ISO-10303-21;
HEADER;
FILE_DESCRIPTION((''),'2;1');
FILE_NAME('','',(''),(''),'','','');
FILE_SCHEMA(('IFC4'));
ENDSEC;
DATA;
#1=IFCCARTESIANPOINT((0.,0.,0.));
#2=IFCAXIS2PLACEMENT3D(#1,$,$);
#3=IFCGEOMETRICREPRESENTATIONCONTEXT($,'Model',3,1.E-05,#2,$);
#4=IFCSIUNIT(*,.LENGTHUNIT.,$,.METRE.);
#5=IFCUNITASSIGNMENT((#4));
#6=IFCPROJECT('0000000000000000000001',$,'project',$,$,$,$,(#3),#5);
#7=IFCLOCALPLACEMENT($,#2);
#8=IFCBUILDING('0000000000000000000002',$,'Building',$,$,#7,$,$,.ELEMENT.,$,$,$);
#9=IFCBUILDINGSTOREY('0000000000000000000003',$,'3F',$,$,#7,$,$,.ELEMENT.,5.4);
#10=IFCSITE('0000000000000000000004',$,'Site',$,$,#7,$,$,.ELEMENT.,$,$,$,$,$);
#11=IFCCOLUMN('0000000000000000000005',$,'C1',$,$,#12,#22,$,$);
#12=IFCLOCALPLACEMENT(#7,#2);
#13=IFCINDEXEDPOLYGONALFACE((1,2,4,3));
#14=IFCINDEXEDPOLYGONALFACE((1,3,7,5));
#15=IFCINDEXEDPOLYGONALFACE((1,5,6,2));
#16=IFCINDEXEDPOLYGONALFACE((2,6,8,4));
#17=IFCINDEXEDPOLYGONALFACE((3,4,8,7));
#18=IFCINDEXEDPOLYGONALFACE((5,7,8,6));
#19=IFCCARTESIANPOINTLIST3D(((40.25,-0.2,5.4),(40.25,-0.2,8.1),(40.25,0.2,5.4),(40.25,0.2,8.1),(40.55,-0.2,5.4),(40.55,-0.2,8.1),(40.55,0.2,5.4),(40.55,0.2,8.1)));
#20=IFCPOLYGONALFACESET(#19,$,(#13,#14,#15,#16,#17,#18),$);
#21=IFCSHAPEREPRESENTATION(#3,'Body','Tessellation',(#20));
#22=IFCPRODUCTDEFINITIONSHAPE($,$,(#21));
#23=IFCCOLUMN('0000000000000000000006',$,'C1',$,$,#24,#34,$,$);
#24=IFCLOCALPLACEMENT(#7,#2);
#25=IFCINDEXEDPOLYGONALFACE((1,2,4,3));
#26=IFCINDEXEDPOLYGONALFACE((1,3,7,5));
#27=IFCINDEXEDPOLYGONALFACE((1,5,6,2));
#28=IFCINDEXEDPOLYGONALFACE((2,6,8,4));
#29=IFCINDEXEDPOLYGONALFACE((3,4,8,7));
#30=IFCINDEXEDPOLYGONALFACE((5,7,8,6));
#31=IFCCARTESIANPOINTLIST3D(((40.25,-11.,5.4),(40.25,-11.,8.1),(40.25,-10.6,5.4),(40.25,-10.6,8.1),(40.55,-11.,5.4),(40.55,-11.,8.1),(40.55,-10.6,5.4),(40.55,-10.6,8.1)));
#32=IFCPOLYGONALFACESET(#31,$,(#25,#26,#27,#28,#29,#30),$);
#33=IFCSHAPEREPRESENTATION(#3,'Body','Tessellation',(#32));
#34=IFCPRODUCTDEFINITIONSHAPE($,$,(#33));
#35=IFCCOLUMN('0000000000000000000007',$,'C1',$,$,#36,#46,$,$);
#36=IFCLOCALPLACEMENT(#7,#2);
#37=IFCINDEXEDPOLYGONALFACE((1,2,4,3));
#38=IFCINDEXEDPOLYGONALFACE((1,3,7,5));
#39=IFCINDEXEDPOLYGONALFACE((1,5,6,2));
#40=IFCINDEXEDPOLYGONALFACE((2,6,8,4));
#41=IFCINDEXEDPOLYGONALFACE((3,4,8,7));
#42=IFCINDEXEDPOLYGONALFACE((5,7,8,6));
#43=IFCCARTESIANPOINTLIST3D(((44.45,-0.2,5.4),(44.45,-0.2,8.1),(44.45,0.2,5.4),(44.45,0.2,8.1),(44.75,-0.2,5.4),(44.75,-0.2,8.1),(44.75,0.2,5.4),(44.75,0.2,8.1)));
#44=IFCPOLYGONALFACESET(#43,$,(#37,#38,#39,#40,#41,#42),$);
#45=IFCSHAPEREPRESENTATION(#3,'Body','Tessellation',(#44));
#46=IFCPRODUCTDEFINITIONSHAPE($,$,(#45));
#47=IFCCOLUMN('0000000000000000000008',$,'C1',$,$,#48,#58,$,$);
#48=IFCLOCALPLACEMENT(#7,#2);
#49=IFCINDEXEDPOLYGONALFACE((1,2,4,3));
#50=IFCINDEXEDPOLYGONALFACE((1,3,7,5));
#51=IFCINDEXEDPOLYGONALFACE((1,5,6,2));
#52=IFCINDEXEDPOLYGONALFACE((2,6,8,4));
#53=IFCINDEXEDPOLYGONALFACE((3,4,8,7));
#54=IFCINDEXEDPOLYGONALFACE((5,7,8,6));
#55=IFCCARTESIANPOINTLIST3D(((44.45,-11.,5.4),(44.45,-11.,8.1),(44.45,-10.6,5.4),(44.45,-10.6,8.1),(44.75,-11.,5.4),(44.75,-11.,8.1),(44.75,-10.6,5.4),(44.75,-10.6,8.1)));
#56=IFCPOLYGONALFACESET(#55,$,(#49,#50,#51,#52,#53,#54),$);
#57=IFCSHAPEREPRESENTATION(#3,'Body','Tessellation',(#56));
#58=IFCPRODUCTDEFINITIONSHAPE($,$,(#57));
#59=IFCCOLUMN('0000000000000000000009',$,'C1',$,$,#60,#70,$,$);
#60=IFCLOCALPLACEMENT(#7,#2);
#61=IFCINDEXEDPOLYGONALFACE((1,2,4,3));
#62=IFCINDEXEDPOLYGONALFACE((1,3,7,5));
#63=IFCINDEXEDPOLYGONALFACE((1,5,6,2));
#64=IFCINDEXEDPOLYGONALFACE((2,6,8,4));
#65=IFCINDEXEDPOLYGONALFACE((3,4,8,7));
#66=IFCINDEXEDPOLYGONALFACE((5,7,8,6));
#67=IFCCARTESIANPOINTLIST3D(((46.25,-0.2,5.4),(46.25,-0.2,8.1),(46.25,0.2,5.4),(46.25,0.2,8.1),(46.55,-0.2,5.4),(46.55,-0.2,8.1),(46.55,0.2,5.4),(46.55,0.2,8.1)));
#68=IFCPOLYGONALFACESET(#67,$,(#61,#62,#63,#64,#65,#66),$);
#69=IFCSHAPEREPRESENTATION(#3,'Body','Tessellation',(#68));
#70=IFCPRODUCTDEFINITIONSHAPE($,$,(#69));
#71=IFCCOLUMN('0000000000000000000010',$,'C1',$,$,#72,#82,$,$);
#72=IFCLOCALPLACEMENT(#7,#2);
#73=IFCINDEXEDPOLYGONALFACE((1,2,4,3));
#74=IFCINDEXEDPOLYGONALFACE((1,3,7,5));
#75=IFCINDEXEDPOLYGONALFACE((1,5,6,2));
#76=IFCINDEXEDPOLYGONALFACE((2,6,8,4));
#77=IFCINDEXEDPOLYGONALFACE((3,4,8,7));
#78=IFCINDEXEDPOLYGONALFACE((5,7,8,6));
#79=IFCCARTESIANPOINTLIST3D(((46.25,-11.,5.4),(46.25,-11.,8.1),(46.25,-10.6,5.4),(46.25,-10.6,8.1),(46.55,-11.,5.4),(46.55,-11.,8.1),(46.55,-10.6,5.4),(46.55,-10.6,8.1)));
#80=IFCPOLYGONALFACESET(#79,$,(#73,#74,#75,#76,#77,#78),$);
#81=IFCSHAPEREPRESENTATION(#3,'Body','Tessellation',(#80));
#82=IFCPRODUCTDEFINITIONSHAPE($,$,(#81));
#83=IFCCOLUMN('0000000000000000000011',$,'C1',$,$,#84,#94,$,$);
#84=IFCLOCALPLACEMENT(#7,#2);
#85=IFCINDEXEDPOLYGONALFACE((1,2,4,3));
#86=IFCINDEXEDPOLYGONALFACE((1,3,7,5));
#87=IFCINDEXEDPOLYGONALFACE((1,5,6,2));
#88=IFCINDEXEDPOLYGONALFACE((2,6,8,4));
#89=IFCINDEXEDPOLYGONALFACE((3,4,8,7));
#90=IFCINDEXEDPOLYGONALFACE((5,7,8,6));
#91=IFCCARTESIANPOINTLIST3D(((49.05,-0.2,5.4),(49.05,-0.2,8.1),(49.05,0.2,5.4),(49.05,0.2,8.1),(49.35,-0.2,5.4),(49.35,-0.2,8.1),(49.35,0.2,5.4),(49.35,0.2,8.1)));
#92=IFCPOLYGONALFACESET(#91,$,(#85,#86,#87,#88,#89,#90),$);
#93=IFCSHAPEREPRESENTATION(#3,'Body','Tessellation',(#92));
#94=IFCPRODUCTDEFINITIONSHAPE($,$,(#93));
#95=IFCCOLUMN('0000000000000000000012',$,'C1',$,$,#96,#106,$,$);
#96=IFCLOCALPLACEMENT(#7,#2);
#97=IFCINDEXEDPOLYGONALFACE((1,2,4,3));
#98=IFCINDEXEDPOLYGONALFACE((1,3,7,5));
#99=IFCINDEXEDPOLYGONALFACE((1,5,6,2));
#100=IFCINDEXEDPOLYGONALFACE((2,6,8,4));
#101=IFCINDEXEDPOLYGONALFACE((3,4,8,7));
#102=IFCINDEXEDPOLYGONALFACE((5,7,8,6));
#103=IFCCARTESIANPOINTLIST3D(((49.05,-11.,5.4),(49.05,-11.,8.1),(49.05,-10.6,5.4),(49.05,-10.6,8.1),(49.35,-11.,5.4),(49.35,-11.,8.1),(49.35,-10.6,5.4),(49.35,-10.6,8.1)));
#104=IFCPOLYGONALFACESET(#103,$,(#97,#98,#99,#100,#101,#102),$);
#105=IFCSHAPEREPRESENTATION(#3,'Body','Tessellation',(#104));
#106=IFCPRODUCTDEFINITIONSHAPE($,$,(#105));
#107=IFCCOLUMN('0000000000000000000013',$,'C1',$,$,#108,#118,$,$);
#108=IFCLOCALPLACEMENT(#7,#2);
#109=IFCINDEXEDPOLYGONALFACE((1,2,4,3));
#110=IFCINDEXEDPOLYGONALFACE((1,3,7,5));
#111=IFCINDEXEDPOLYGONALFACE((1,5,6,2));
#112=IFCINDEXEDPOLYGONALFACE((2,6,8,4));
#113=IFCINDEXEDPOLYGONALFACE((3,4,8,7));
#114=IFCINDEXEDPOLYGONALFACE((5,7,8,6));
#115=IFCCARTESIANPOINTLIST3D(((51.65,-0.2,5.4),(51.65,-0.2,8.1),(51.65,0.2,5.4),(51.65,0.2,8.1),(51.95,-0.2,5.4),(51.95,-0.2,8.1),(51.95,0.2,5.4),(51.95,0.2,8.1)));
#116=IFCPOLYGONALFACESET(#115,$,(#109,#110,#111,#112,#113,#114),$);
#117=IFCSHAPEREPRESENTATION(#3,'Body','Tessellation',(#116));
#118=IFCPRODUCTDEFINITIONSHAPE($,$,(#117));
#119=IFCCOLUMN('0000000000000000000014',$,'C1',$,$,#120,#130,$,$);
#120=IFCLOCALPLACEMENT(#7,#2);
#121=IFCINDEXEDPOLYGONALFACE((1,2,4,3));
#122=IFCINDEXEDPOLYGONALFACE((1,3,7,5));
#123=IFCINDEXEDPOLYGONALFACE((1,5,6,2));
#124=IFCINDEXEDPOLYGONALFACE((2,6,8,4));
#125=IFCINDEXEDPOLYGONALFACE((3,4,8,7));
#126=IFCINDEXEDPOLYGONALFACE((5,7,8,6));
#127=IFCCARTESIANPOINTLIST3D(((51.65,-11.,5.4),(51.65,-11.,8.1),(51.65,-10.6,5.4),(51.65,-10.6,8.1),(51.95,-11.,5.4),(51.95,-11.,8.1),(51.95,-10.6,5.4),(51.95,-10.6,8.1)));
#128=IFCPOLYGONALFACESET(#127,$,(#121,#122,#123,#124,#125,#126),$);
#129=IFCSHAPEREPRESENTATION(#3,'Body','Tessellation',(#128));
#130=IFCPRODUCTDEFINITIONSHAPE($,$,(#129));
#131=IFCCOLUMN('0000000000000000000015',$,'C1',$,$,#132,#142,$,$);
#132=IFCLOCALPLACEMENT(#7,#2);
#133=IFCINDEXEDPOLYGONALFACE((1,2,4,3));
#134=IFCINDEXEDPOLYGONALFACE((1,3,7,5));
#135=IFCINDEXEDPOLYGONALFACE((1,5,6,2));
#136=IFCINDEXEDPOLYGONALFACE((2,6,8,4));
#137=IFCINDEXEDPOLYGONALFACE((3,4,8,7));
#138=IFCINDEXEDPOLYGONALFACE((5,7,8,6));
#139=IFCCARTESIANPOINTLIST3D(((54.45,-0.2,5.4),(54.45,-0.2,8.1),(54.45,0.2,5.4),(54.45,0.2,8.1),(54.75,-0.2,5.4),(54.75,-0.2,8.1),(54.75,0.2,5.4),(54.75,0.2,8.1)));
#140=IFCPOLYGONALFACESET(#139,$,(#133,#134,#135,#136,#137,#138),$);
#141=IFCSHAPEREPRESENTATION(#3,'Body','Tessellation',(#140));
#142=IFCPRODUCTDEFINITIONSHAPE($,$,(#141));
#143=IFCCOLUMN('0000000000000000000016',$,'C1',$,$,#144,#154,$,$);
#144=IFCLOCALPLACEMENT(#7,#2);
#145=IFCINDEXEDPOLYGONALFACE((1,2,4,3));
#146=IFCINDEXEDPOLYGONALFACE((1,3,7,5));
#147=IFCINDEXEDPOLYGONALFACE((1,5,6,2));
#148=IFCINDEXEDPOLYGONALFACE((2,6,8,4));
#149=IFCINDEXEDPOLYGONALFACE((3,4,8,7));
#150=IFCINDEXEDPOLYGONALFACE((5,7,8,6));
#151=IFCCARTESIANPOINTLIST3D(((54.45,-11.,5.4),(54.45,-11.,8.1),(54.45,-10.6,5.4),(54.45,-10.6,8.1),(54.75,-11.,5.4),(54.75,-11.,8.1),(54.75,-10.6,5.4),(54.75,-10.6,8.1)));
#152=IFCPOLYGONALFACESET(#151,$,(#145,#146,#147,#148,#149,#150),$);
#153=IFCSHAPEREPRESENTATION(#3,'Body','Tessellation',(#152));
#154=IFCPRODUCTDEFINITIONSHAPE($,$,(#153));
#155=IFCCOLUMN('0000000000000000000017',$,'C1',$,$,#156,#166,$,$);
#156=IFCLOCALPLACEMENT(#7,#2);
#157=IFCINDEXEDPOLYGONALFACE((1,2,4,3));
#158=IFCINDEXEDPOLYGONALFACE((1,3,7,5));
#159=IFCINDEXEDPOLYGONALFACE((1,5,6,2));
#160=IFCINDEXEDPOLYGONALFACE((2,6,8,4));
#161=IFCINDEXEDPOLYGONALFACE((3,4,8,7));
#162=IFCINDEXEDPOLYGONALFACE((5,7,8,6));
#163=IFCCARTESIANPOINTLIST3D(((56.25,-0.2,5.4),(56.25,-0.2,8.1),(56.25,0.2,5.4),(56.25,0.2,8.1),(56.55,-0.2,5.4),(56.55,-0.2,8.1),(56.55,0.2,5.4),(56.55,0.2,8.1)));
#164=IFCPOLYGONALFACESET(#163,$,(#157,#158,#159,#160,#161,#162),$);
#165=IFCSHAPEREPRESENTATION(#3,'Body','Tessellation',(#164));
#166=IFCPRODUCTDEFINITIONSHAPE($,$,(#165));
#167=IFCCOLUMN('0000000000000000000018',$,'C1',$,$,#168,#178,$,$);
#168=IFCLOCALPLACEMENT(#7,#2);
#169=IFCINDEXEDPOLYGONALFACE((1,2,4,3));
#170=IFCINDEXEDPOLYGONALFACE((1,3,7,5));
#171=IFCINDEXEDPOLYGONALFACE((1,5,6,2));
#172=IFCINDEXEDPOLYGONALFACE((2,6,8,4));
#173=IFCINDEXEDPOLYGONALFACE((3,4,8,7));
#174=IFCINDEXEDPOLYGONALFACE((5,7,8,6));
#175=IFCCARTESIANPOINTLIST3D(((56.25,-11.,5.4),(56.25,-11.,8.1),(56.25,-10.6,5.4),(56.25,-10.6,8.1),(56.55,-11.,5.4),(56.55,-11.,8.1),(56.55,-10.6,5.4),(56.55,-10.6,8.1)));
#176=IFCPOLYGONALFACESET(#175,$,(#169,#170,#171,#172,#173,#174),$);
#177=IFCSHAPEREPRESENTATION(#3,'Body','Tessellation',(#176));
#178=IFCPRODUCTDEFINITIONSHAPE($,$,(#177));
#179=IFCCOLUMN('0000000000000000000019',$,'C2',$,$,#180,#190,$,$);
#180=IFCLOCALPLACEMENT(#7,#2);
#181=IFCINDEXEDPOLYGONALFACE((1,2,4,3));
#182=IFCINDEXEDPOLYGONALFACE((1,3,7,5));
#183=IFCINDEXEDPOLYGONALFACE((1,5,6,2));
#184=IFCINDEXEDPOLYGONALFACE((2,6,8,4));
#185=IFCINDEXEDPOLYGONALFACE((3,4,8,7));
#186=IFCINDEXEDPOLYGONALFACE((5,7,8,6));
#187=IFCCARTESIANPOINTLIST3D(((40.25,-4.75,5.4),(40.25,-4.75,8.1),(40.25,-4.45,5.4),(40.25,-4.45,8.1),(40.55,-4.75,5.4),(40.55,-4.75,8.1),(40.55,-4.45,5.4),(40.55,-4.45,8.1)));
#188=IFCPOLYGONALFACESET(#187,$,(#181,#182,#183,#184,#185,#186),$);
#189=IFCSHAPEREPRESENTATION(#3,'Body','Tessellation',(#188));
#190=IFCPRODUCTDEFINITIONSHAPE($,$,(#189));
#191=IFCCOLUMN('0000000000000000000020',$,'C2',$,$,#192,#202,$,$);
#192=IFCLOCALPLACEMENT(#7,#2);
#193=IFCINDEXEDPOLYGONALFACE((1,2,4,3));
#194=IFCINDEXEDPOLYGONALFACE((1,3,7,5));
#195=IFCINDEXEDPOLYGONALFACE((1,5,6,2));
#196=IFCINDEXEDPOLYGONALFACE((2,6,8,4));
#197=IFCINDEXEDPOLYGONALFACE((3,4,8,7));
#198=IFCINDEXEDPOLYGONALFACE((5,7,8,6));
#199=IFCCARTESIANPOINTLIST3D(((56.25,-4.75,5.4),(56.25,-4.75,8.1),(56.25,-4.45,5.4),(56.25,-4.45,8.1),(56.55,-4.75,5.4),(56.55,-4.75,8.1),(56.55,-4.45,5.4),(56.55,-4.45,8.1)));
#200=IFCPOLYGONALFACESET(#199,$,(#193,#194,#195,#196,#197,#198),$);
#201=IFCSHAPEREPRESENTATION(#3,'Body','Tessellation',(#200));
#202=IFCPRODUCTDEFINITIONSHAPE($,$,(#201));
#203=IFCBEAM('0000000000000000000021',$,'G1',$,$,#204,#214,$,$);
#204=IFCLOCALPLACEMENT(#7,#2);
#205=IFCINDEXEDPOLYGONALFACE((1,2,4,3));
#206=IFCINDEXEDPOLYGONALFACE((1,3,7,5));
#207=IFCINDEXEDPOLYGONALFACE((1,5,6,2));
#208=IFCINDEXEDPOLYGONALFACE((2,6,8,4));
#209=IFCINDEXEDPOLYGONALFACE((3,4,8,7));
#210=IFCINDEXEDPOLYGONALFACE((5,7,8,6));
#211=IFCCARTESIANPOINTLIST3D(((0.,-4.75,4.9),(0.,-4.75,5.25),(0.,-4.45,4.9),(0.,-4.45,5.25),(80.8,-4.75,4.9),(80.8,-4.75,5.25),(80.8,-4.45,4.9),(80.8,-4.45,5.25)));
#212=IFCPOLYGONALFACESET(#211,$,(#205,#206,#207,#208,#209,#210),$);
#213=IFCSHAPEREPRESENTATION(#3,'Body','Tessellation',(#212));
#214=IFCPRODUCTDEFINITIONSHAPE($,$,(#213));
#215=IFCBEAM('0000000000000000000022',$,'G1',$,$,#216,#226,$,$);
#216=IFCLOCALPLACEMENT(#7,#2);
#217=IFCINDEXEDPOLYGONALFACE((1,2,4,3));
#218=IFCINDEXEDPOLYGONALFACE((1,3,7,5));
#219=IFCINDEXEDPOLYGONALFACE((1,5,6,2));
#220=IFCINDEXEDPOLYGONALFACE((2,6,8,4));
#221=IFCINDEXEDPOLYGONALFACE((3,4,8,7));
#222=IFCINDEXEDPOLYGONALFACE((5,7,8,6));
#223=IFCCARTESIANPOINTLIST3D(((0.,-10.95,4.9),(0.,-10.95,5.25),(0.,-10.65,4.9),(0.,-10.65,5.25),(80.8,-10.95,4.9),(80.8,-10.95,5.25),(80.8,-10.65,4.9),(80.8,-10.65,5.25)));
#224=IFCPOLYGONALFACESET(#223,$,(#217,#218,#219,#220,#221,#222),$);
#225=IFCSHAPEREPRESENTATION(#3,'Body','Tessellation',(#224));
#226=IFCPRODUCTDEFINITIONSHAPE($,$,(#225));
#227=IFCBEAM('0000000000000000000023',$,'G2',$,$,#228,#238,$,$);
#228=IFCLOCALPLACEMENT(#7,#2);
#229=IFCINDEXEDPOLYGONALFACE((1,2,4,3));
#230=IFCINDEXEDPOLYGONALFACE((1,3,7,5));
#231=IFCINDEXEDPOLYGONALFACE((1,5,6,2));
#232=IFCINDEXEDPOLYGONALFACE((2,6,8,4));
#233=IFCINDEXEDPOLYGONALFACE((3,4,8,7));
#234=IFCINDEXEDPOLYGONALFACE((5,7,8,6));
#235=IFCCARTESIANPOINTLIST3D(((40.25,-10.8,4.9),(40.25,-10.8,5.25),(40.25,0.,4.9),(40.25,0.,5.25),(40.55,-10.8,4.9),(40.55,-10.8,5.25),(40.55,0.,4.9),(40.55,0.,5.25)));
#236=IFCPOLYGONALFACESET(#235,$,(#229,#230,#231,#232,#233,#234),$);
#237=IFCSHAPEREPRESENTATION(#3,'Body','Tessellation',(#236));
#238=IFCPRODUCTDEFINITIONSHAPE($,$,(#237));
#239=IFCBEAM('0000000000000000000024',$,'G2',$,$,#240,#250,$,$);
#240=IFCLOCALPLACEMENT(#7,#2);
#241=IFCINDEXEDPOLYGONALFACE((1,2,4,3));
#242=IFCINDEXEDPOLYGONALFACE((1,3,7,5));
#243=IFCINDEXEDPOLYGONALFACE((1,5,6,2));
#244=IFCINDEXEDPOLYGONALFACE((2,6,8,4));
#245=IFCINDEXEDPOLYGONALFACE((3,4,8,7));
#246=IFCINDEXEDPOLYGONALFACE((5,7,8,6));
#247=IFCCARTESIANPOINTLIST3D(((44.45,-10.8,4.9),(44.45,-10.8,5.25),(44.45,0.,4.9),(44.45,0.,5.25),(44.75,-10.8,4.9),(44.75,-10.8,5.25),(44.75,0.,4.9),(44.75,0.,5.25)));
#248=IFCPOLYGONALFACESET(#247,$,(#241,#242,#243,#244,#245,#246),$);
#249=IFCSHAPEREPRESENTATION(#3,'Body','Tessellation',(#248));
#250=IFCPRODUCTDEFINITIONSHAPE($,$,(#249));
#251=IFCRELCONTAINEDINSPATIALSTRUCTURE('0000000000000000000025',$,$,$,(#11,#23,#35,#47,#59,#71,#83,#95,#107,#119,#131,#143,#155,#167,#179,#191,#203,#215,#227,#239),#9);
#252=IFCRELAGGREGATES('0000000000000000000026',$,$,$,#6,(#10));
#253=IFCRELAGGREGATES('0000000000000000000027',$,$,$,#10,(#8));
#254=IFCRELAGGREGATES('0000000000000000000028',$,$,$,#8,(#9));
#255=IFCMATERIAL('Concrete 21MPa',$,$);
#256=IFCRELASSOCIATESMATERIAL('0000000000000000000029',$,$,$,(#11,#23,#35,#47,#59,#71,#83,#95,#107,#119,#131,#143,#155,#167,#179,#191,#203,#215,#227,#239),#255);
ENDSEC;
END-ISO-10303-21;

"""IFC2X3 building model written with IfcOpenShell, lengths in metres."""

from ifc_helpers import new_model, si_unit, frame, origin, origin_2d, place, context, project, spatial, rectangle, extrude, material, element, save


model = new_model("IFC2X3")

# Units and contexts
model_context = context("Model", 3, precision=1e-05, world=origin())
ifc_project = project(units=[si_unit("LENGTHUNIT", "METRE")], contexts=[model_context])

# Site, building, storey
placement = place(None, origin())
site = spatial("IfcSite", under=ifc_project, at=placement, Name="Site", CompositionType="ELEMENT")
building = spatial("IfcBuilding", under=site, at=placement, Name="Building", CompositionType="ELEMENT")
storey = spatial("IfcBuildingStorey", under=building, at=placement, Name="3F", CompositionType="ELEMENT", Elevation=5.4)

# Columns
ifc_material = material(Name="Concrete 21MPa")
for number, where, name in (
    (1, (40.4, 0.0, 5.4), "C1"),
    (2, (40.4, -10.8, 5.4), "C1"),
    (3, (44.6, 0.0, 5.4), "C1"),
    (4, (44.6, -10.8, 5.4), "C1"),
    (5, (46.4, 0.0, 5.4), "C1"),
    (6, (46.4, -10.8, 5.4), "C1"),
    (7, (49.2, 0.0, 5.4), "C1"),
    (8, (49.2, -10.8, 5.4), "C1"),
    (9, (51.8, 0.0, 5.4), "C1"),
    (10, (51.8, -10.8, 5.4), "C1"),
    (11, (54.6, 0.0, 5.4), "C1"),
    (12, (54.6, -10.8, 5.4), "C1"),
    (13, (56.4, 0.0, 5.4), "C1"),
    (14, (56.4, -10.8, 5.4), "C1"),
):
    element("IfcColumn", number, at=place(None, frame(where)), inside=storey, material=ifc_material, Name=name, context=model_context, shape_type="SweptSolid", body=[
        extrude(rectangle(XDim=0.3, YDim=0.4, at=origin_2d()), origin(), (0.0, 0.0, 1.0), 2.7),
    ])
for number, where, name in (
    (15, (40.4, -4.6, 5.4), "C2"),
    (16, (56.4, -4.6, 5.4), "C2"),
):
    element("IfcColumn", number, at=place(None, frame(where)), inside=storey, material=ifc_material, Name=name, context=model_context, shape_type="SweptSolid", body=[
        extrude(rectangle(XDim=0.3, YDim=0.3, at=origin_2d()), origin(), (0.0, 0.0, 1.0), 2.7),
    ])

# Beams
for number, where, name in (
    (17, (40.4, -4.6, 4.9), "G1"),
    (18, (40.4, -10.8, 4.9), "G1"),
):
    element("IfcBeam", number, at=place(None, frame(where)), inside=storey, material=ifc_material, Name=name, context=model_context, shape_type="SweptSolid", body=[
        extrude(rectangle(XDim=80.8, YDim=0.3, at=origin_2d()), origin(), (0.0, 0.0, 1.0), 0.35),
    ])
for number, where, name in (
    (19, (40.4, -5.4, 4.9), "G2"),
    (20, (44.6, -5.4, 4.9), "G2"),
):
    element("IfcBeam", number, at=place(None, frame(where)), inside=storey, material=ifc_material, Name=name, context=model_context, shape_type="SweptSolid", body=[
        extrude(rectangle(XDim=0.3, YDim=10.8, at=origin_2d()), origin(), (0.0, 0.0, 1.0), 0.35),
    ])

save(model, "model.ifc")
